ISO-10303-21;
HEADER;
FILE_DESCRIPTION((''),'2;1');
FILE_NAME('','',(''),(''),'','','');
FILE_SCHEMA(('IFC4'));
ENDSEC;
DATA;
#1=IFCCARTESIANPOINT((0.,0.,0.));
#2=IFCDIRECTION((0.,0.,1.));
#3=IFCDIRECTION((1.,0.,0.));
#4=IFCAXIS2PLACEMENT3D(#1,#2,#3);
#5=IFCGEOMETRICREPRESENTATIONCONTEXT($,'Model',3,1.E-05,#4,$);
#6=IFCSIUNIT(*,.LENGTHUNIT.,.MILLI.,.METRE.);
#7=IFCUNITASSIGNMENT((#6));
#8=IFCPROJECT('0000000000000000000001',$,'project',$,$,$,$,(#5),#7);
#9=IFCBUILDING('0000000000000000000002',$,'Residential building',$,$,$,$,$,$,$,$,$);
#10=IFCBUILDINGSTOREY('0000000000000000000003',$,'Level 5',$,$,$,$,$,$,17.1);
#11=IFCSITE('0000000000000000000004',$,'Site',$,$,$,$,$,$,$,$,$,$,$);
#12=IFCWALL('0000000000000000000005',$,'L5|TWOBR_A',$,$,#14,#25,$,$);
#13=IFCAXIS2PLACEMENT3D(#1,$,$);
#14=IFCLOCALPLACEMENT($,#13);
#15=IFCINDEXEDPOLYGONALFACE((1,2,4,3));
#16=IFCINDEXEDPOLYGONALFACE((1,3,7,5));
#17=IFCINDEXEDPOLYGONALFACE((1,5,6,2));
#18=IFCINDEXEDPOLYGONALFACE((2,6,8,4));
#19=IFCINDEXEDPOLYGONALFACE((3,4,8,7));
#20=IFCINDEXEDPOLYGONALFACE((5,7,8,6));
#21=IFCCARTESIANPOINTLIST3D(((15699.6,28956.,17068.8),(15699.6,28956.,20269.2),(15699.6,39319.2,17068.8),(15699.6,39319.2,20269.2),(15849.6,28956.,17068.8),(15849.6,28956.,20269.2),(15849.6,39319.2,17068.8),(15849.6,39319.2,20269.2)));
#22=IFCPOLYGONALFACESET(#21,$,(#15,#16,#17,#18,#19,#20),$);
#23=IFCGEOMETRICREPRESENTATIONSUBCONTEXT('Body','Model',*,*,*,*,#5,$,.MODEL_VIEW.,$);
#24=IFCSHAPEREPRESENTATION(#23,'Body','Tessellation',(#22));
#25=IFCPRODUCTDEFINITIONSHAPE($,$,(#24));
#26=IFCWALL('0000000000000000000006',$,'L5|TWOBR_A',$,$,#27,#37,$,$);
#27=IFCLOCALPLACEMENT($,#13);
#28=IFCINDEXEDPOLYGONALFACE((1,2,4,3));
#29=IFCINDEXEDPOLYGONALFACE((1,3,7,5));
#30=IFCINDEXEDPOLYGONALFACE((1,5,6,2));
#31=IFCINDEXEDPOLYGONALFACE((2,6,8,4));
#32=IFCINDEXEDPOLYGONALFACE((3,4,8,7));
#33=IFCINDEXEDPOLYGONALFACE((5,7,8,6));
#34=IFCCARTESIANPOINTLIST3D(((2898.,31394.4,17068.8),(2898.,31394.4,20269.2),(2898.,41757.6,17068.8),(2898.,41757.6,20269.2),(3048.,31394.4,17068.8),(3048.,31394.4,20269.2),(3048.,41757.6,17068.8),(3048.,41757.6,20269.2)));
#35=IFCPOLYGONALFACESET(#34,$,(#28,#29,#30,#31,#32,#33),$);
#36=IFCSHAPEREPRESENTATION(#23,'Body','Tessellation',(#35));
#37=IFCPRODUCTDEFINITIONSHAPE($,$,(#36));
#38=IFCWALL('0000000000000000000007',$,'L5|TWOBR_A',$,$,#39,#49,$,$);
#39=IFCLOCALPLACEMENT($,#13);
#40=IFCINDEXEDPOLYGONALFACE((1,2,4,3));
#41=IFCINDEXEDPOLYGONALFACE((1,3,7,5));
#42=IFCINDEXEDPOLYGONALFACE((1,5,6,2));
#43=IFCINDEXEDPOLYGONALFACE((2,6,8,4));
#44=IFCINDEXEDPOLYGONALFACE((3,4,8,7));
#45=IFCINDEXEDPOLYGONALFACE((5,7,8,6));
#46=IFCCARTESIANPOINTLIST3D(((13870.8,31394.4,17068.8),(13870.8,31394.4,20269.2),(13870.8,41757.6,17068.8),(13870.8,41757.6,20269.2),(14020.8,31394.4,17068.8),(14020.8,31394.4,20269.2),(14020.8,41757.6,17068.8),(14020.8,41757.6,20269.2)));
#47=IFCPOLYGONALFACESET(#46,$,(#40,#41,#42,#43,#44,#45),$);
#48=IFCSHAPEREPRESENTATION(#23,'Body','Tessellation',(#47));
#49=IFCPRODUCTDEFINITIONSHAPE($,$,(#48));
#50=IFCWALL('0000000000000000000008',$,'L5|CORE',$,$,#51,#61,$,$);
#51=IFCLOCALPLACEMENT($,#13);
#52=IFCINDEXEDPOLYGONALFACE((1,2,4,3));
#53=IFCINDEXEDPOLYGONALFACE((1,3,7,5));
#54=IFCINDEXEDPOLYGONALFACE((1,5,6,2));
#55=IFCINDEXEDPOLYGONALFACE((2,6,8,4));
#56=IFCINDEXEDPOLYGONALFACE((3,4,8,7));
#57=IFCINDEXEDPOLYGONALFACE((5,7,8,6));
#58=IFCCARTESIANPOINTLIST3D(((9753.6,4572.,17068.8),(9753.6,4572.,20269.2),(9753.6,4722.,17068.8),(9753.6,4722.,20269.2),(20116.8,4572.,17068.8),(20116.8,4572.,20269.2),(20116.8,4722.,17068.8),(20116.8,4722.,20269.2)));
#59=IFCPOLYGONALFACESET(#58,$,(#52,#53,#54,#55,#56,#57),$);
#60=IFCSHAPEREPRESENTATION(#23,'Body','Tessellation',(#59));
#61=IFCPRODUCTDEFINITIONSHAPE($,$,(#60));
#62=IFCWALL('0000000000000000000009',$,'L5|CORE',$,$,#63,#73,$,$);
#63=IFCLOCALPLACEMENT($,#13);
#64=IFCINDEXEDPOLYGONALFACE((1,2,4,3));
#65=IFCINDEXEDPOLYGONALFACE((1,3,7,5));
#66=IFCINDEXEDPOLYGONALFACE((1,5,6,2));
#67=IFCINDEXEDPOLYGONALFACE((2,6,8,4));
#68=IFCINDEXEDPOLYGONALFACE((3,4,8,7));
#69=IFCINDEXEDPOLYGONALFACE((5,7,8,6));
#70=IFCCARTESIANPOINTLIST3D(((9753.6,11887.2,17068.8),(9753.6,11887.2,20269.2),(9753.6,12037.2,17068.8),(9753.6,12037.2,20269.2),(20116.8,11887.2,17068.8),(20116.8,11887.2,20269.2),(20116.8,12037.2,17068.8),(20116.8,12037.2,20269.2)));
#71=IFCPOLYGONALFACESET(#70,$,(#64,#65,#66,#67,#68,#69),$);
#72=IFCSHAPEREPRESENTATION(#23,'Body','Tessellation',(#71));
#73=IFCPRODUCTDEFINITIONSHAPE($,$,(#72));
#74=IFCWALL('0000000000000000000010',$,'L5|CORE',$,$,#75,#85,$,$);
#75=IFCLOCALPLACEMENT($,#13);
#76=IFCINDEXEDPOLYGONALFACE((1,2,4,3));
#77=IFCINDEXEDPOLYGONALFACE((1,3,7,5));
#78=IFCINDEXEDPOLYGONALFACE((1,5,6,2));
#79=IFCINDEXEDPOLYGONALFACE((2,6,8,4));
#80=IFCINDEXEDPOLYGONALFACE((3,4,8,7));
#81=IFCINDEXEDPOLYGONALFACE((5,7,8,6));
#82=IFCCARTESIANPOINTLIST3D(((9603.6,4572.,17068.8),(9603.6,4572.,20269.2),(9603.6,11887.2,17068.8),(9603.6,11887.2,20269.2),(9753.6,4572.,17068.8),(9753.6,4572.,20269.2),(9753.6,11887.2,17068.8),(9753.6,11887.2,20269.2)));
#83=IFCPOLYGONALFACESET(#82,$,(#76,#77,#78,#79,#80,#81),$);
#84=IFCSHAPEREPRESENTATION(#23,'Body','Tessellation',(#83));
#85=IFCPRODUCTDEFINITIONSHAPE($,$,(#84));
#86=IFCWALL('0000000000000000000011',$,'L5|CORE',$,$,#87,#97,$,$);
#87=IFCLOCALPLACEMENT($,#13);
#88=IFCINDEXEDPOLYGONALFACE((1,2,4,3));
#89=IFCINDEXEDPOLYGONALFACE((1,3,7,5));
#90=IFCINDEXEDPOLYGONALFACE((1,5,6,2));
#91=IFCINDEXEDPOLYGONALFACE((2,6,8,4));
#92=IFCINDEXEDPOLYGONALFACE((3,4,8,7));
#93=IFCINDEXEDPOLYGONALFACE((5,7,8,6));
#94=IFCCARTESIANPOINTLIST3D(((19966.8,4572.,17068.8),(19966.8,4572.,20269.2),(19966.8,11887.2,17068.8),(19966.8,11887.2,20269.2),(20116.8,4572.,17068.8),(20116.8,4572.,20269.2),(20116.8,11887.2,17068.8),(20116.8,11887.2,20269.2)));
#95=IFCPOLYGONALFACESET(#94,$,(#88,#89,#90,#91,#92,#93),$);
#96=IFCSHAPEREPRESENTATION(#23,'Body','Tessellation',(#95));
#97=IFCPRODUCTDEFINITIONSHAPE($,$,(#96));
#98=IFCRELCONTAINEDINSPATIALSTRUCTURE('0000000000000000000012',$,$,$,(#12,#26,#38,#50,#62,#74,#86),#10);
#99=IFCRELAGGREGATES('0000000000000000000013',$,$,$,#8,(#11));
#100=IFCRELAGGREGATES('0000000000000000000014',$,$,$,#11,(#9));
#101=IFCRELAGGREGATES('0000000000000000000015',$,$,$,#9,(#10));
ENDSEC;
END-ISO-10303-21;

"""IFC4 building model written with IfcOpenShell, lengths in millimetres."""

from ifc_helpers import new_model, si_unit, frame, origin_with_axes, place, context, subcontext, project, spatial, indexed_curve, outline, extrude, element, save


model = new_model("IFC4")

# Units and contexts
model_context = context("Model", 3, precision=1e-05, world=origin_with_axes())
body_context = subcontext(model_context, "Body", "Model", "MODEL_VIEW")
ifc_project = project(units=[si_unit("LENGTHUNIT", "METRE", prefix="MILLI")], contexts=[model_context])

# Site, building, storey
site = spatial("IfcSite", under=ifc_project, Name="Site")
building = spatial("IfcBuilding", under=site, Name="Residential building")
storey = spatial("IfcBuildingStorey", under=building, Name="Level 5", Elevation=17.1)

# Walls
wall_1_placement = place(None, frame((15849.6, 28956.0, 17068.8), z_axis=(0.0, 0.0, 1.0), x_axis=(0.0, 1.0, 0.0)))
element("IfcWall", 1, at=wall_1_placement, inside=storey, Name="L5|TWOBR_A", context=body_context, shape_type="SweptSolid", body=[
    extrude(outline(indexed_curve([(0.0, 0.0), (0.0, 150.0), (10363.2, 150.0), (10363.2, 0.0), (0.0, 0.0)], self_intersect=False)), origin_with_axes(), (0.0, 0.0, 1.0), 3200.4),
])
for number, where, z_axis, x_axis, name in (
    (2, (3048.0, 31394.4, 17068.8), (0.0, 0.0, 1.0), (0.0, 1.0, 0.0), "L5|TWOBR_A"),
    (3, (14020.8, 31394.4, 17068.8), (0.0, 0.0, 1.0), (0.0, 1.0, 0.0), "L5|TWOBR_A"),
    (4, (9753.6, 4572.0, 17068.8), (0.0, 0.0, 1.0), (1.0, 0.0, 0.0), "L5|CORE"),
    (5, (9753.6, 11887.2, 17068.8), (0.0, 0.0, 1.0), (1.0, 0.0, 0.0), "L5|CORE"),
):
    element("IfcWall", number, at=place(None, frame(where, z_axis=z_axis, x_axis=x_axis)), inside=storey, Name=name, context=body_context, shape_type="SweptSolid", body=[
        extrude(outline(indexed_curve([(0.0, 0.0), (0.0, 150.0), (10363.2, 150.0), (10363.2, 0.0), (0.0, 0.0)], self_intersect=False)), origin_with_axes(), (0.0, 0.0, 1.0), 3200.4),
    ])
for number, where, z_axis, x_axis, name in (
    (6, (9753.6, 4572.0, 17068.8), (0.0, 0.0, 1.0), (0.0, 1.0, 0.0), "L5|CORE"),
    (7, (20116.8, 4572.0, 17068.8), (0.0, 0.0, 1.0), (0.0, 1.0, 0.0), "L5|CORE"),
):
    element("IfcWall", number, at=place(None, frame(where, z_axis=z_axis, x_axis=x_axis)), inside=storey, Name=name, context=body_context, shape_type="SweptSolid", body=[
        extrude(outline(indexed_curve([(0.0, 0.0), (0.0, 150.0), (7315.2, 150.0), (7315.2, 0.0), (0.0, 0.0)], self_intersect=False)), origin_with_axes(), (0.0, 0.0, 1.0), 3200.4),
    ])

save(model, "model.ifc")
